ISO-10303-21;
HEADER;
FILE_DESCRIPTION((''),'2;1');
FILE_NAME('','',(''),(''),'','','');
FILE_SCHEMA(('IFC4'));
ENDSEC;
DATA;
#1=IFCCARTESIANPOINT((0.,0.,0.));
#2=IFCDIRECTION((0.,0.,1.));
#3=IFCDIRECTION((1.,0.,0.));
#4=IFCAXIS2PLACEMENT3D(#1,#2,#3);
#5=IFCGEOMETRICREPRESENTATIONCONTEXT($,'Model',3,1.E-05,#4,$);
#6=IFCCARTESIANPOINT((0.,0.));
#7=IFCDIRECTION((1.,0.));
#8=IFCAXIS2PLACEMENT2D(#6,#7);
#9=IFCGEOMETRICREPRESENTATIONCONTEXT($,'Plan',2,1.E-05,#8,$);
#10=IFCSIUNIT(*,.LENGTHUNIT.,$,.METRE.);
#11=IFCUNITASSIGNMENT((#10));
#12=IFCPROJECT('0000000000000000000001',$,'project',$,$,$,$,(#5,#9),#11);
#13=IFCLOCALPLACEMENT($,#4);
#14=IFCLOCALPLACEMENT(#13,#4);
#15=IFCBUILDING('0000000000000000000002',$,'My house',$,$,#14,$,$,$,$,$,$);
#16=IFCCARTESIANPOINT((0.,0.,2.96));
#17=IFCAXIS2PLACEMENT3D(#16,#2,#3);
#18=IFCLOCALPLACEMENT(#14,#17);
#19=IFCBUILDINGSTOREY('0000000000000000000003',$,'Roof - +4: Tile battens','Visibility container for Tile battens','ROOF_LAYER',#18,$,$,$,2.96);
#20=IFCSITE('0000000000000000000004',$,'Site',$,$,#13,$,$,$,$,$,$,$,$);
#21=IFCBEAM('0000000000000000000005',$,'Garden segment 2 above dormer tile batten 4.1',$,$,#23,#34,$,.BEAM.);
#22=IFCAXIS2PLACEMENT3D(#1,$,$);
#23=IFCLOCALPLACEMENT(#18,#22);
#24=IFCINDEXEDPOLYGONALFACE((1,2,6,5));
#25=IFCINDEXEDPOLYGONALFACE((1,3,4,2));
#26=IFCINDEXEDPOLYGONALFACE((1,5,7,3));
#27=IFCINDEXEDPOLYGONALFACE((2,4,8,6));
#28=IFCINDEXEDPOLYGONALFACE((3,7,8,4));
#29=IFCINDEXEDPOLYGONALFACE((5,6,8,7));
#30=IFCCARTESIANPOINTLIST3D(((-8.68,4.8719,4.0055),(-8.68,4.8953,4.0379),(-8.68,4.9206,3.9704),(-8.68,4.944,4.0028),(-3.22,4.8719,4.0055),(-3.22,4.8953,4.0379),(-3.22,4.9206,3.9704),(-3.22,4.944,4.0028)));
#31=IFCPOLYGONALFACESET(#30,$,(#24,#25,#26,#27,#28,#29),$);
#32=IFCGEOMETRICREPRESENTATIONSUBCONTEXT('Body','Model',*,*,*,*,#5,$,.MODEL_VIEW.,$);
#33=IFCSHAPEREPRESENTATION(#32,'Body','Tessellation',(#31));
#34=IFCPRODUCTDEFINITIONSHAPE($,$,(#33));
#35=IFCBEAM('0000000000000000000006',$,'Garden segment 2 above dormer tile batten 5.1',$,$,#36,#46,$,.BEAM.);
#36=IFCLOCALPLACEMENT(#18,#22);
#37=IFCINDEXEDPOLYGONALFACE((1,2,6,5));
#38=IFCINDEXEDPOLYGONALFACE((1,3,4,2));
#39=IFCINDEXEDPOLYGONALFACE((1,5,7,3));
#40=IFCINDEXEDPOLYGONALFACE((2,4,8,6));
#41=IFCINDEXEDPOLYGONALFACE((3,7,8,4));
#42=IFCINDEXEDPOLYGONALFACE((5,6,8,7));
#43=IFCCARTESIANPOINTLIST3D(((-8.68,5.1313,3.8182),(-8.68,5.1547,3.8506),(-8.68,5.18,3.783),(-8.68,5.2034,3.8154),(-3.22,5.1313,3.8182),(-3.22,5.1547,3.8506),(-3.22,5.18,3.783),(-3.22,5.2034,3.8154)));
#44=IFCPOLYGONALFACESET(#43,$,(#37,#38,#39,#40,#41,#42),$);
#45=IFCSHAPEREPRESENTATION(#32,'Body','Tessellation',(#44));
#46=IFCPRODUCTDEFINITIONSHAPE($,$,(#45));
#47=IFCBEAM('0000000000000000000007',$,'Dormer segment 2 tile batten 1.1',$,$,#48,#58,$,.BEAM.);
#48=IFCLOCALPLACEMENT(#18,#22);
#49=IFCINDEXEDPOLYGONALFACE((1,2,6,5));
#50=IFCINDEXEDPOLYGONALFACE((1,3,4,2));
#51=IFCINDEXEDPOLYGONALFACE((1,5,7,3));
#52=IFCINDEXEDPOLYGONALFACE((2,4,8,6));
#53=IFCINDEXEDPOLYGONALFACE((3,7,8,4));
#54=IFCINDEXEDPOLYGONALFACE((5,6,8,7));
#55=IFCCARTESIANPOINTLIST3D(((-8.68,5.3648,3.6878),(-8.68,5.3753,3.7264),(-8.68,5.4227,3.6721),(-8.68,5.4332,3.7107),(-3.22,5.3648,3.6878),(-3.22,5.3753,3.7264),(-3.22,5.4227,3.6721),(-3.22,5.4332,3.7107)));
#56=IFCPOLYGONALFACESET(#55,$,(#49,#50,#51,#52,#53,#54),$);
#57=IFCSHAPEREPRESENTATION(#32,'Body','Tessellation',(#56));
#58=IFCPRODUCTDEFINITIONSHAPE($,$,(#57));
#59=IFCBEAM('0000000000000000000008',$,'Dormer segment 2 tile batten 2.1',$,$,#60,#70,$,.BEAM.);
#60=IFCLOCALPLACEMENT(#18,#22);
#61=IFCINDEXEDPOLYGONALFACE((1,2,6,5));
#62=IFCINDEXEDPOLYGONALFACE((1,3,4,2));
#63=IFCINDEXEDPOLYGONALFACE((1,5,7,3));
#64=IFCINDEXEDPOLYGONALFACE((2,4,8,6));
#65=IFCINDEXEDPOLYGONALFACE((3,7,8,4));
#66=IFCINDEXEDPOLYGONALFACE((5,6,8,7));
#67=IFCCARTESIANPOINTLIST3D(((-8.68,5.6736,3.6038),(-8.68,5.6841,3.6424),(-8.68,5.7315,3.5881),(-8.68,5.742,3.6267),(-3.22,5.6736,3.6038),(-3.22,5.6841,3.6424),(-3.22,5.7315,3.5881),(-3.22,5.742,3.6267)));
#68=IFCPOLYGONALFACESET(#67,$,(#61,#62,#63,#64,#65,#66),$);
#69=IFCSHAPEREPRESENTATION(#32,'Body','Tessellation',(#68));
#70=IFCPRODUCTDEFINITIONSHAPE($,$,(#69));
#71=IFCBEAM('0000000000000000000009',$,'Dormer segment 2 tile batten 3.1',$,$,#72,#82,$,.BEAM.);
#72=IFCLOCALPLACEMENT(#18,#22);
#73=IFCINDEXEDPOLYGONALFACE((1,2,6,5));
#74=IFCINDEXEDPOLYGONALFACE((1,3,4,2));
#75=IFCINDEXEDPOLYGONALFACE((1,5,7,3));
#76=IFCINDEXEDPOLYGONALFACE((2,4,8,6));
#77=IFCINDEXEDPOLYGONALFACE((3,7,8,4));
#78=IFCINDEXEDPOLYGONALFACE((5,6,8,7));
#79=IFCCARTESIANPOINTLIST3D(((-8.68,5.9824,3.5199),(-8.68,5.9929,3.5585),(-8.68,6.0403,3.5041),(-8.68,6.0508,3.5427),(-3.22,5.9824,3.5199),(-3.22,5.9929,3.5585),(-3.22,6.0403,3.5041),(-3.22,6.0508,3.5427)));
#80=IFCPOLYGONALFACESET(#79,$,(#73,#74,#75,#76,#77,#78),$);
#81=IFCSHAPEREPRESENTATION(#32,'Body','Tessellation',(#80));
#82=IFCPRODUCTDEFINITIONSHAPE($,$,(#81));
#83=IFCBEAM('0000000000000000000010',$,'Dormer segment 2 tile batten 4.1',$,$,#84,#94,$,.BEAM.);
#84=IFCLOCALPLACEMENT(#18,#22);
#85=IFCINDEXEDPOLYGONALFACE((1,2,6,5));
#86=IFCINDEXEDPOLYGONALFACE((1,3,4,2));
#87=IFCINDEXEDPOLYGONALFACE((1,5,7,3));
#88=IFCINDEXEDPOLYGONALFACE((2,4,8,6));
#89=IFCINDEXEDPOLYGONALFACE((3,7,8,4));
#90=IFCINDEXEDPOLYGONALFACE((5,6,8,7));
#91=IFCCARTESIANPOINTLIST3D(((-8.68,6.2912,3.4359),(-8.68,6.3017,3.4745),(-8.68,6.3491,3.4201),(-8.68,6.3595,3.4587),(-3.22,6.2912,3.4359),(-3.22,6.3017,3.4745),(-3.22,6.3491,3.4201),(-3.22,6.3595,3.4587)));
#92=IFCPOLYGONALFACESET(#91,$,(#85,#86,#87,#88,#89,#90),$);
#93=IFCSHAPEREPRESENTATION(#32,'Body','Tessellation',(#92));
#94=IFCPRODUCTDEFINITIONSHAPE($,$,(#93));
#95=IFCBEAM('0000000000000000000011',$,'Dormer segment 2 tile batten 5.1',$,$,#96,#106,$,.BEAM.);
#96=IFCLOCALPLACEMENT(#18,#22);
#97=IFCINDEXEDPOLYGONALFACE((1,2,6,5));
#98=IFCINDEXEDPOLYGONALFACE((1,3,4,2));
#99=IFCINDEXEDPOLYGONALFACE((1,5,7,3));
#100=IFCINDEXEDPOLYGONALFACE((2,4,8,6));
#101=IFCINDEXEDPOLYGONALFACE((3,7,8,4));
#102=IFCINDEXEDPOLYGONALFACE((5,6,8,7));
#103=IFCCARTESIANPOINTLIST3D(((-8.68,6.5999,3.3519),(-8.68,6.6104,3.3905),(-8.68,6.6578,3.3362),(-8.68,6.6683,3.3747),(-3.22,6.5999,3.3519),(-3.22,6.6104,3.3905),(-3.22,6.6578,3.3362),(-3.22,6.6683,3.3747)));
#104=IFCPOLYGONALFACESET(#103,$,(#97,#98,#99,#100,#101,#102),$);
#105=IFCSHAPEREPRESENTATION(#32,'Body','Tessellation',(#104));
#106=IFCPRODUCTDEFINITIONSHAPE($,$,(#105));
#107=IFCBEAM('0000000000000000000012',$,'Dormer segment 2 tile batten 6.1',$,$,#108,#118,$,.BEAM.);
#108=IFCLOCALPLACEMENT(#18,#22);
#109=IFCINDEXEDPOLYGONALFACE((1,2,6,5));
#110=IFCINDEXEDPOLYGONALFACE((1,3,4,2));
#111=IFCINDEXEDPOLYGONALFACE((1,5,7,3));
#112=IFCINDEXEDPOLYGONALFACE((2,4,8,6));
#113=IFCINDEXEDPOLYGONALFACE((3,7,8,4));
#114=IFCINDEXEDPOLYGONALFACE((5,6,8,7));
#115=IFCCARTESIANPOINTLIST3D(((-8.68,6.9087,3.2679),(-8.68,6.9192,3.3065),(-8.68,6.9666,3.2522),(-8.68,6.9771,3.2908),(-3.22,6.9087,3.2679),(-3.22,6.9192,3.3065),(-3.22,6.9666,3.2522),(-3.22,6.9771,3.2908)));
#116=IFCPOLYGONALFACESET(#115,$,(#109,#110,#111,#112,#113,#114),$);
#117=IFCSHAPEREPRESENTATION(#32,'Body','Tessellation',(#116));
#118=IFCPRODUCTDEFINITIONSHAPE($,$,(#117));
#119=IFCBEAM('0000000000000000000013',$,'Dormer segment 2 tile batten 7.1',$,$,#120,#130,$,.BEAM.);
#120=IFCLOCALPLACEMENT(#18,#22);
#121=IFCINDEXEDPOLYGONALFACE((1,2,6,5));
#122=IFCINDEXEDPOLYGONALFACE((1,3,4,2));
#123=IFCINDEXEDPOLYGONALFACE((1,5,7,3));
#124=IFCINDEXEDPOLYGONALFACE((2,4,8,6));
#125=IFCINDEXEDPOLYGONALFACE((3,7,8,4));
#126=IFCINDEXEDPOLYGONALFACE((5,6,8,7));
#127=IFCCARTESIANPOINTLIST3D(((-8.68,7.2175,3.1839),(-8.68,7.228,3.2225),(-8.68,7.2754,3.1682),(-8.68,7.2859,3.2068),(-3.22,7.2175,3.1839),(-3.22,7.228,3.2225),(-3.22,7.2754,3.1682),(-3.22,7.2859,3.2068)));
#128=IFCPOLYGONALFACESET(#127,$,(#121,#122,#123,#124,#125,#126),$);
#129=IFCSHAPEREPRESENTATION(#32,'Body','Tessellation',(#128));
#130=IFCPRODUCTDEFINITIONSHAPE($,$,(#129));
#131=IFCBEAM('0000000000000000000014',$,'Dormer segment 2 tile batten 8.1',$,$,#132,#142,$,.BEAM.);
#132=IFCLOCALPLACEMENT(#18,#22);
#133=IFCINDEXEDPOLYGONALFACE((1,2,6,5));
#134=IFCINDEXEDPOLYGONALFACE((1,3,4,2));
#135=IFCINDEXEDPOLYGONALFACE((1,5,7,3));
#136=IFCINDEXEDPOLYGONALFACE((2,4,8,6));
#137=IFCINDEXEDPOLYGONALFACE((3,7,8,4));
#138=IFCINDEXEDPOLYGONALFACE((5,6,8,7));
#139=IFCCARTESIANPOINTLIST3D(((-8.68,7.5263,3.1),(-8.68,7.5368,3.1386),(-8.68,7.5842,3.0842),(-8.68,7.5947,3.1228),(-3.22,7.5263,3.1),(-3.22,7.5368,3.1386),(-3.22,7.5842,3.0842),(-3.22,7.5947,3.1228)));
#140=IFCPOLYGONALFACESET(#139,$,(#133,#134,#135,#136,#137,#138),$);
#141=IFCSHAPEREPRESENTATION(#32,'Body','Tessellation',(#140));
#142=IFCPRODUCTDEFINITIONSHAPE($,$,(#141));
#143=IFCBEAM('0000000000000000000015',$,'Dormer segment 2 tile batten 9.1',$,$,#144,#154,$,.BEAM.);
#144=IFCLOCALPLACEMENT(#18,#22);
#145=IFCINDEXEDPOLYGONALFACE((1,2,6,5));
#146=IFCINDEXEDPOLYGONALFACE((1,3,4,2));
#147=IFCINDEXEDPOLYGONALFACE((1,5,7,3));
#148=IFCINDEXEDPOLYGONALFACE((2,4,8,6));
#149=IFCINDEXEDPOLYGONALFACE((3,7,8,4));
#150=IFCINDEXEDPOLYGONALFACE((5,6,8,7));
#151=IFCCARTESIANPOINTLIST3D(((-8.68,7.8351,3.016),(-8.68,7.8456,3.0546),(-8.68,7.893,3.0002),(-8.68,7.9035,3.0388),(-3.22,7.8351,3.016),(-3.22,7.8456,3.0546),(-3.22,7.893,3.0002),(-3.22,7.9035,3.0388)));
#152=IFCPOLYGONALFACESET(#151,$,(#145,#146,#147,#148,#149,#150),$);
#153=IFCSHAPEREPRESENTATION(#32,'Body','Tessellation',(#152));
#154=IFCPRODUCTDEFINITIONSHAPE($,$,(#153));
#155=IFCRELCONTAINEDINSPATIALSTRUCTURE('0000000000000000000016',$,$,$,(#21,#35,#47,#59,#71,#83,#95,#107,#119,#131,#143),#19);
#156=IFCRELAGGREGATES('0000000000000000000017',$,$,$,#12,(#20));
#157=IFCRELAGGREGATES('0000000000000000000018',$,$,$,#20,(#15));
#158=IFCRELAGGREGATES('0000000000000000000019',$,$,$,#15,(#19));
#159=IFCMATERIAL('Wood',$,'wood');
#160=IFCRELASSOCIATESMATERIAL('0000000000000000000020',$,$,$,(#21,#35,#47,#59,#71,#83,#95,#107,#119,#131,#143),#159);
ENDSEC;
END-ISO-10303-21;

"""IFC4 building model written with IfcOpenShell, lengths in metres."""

from ifc_helpers import new_model, si_unit, frame, origin_with_axes, origin_2d_with_axis, place, context, subcontext, project, spatial, rectangle, extrude, clip, halfspace, source, transform, mapped, material, element, save


model = new_model("IFC4")

# Units and contexts
model_context = context("Model", 3, precision=1e-05, world=origin_with_axes())
plan_context = context("Plan", 2, precision=1e-05, world=origin_2d_with_axis())
body_context = subcontext(model_context, "Body", "Model", "MODEL_VIEW")
ifc_project = project(units=[si_unit("LENGTHUNIT", "METRE")], contexts=[model_context, plan_context])

# Site, building, storey
site_placement = place(None, origin_with_axes())
site = spatial("IfcSite", under=ifc_project, at=site_placement, Name="Site")
building_placement = place(site_placement, origin_with_axes())
building = spatial("IfcBuilding", under=site, at=building_placement, Name="My house")
storey_placement = place(building_placement, frame((0.0, 0.0, 2.96), z_axis=(0.0, 0.0, 1.0), x_axis=(1.0, 0.0, 0.0)))
storey = spatial("IfcBuildingStorey", under=building, at=storey_placement, Name="Roof - +4: Tile battens", Description="Visibility container for Tile battens", ObjectType="ROOF_LAYER", Elevation=2.96)

# Beams
ifc_material = material(Name="Wood", Category="wood")
shared_shape_1 = source(origin_with_axes(), body_context, "Body", "Clipping", [
    clip(clip(extrude(rectangle(XDim=0.06, YDim=0.04), frame((0.0, 0.0, 0.0), z_axis=(1.0, 0.0, 0.0), x_axis=(0.0, 1.0, 0.0)), (0.0, 0.0, 1.0), 5.46), halfspace(frame((-3.22, 3.3416, -6.1772), z_axis=(0.0, -0.810664, -0.585512), x_axis=(-1.0, 0.0, 0.0)), False)), halfspace(frame((-3.22, 7.1922, -3.396), z_axis=(0.0, 0.810664, 0.585512), x_axis=(1.0, 0.0, 0.0)), False)),
])
beam_1_placement = place(storey_placement, frame((-3.22, 4.9079, 4.0042), z_axis=(0.0, 0.585512, 0.810664), x_axis=(1.0, 0.0, 0.0)))
element("IfcBeam", 1, at=beam_1_placement, inside=storey, material=ifc_material, Name="Garden segment 2 above dormer tile batten 4.1", PredefinedType="BEAM", context=body_context, shape_type="MappedRepresentation", body=[
    mapped(shared_shape_1, transform((0.0, 0.0, 0.0), x_axis=(-1.0, 0.0, 0.0), y_axis=(0.0, 1.0, 0.0), z_axis=(0.0, 0.0, 1.0), scale=1.0)),
])
shared_shape_2 = source(origin_with_axes(), body_context, "Body", "Clipping", [
    clip(clip(extrude(rectangle(XDim=0.06, YDim=0.04), frame((0.0, 0.0, 0.0), z_axis=(1.0, 0.0, 0.0), x_axis=(0.0, 1.0, 0.0)), (0.0, 0.0, 1.0), 5.46), halfspace(frame((-3.22, 3.0216, -6.1772), z_axis=(0.0, -0.810664, -0.585512), x_axis=(-1.0, 0.0, 0.0)), False)), halfspace(frame((-3.22, 6.8722, -3.396), z_axis=(0.0, 0.810664, 0.585512), x_axis=(1.0, 0.0, 0.0)), False)),
])
beam_2_placement = place(storey_placement, frame((-3.22, 5.1674, 3.8168), z_axis=(0.0, 0.585512, 0.810664), x_axis=(1.0, 0.0, 0.0)))
element("IfcBeam", 2, at=beam_2_placement, inside=storey, material=ifc_material, Name="Garden segment 2 above dormer tile batten 5.1", PredefinedType="BEAM", context=body_context, shape_type="MappedRepresentation", body=[
    mapped(shared_shape_2, transform((0.0, 0.0, 0.0), x_axis=(-1.0, 0.0, 0.0), y_axis=(0.0, 1.0, 0.0), z_axis=(0.0, 0.0, 1.0), scale=1.0)),
])
shared_shape_3 = source(origin_with_axes(), body_context, "Body", "Clipping", [
    clip(clip(extrude(rectangle(XDim=0.06, YDim=0.04), frame((0.0, 0.0, 0.0), z_axis=(1.0, 0.0, 0.0), x_axis=(0.0, 1.0, 0.0)), (0.0, 0.0, 1.0), 5.46), halfspace(frame((-3.22, 0.3977, -6.793), z_axis=(0.0, -0.964948, -0.262441), x_axis=(-1.0, 0.0, 0.0)), False)), halfspace(frame((-3.22, 4.9812, -5.5464), z_axis=(0.0, 0.964948, 0.262441), x_axis=(1.0, 0.0, 0.0)), False)),
])
beam_3_placement = place(storey_placement, frame((-3.22, 5.399, 3.6992), z_axis=(0.0, 0.262441, 0.964948), x_axis=(1.0, 0.0, 0.0)))
element("IfcBeam", 3, at=beam_3_placement, inside=storey, material=ifc_material, Name="Dormer segment 2 tile batten 1.1", PredefinedType="BEAM", context=body_context, shape_type="MappedRepresentation", body=[
    mapped(shared_shape_3, transform((0.0, 0.0, 0.0), x_axis=(-1.0, 0.0, 0.0), y_axis=(0.0, 1.0, 0.0), z_axis=(0.0, 0.0, 1.0), scale=1.0)),
])
shared_shape_4 = source(origin_with_axes(), body_context, "Body", "Clipping", [
    clip(clip(extrude(rectangle(XDim=0.06, YDim=0.04), frame((0.0, 0.0, 0.0), z_axis=(1.0, 0.0, 0.0), x_axis=(0.0, 1.0, 0.0)), (0.0, 0.0, 1.0), 5.46), halfspace(frame((-3.22, 0.0777, -6.793), z_axis=(0.0, -0.964948, -0.262441), x_axis=(-1.0, 0.0, 0.0)), False)), halfspace(frame((-3.22, 4.6612, -5.5464), z_axis=(0.0, 0.964948, 0.262441), x_axis=(1.0, 0.0, 0.0)), False)),
])
beam_4_placement = place(storey_placement, frame((-3.22, 5.7078, 3.6153), z_axis=(0.0, 0.262441, 0.964948), x_axis=(1.0, 0.0, 0.0)))
element("IfcBeam", 4, at=beam_4_placement, inside=storey, material=ifc_material, Name="Dormer segment 2 tile batten 2.1", PredefinedType="BEAM", context=body_context, shape_type="MappedRepresentation", body=[
    mapped(shared_shape_4, transform((0.0, 0.0, 0.0), x_axis=(-1.0, 0.0, 0.0), y_axis=(0.0, 1.0, 0.0), z_axis=(0.0, 0.0, 1.0), scale=1.0)),
])
shared_shape_5 = source(origin_with_axes(), body_context, "Body", "Clipping", [
    clip(clip(extrude(rectangle(XDim=0.06, YDim=0.04), frame((0.0, 0.0, 0.0), z_axis=(1.0, 0.0, 0.0), x_axis=(0.0, 1.0, 0.0)), (0.0, 0.0, 1.0), 5.46), halfspace(frame((-3.22, -0.2423, -6.793), z_axis=(0.0, -0.964948, -0.262441), x_axis=(-1.0, 0.0, 0.0)), False)), halfspace(frame((-3.22, 4.3412, -5.5464), z_axis=(0.0, 0.964948, 0.262441), x_axis=(1.0, 0.0, 0.0)), False)),
])
beam_5_placement = place(storey_placement, frame((-3.22, 6.0166, 3.5313), z_axis=(0.0, 0.262441, 0.964948), x_axis=(1.0, 0.0, 0.0)))
element("IfcBeam", 5, at=beam_5_placement, inside=storey, material=ifc_material, Name="Dormer segment 2 tile batten 3.1", PredefinedType="BEAM", context=body_context, shape_type="MappedRepresentation", body=[
    mapped(shared_shape_5, transform((0.0, 0.0, 0.0), x_axis=(-1.0, 0.0, 0.0), y_axis=(0.0, 1.0, 0.0), z_axis=(0.0, 0.0, 1.0), scale=1.0)),
])
shared_shape_6 = source(origin_with_axes(), body_context, "Body", "Clipping", [
    clip(clip(extrude(rectangle(XDim=0.06, YDim=0.04), frame((0.0, 0.0, 0.0), z_axis=(1.0, 0.0, 0.0), x_axis=(0.0, 1.0, 0.0)), (0.0, 0.0, 1.0), 5.46), halfspace(frame((-3.22, -0.5623, -6.793), z_axis=(0.0, -0.964948, -0.262441), x_axis=(-1.0, 0.0, 0.0)), False)), halfspace(frame((-3.22, 4.0212, -5.5464), z_axis=(0.0, 0.964948, 0.262441), x_axis=(1.0, 0.0, 0.0)), False)),
])
beam_6_placement = place(storey_placement, frame((-3.22, 6.3254, 3.4473), z_axis=(0.0, 0.262441, 0.964948), x_axis=(1.0, 0.0, 0.0)))
element("IfcBeam", 6, at=beam_6_placement, inside=storey, material=ifc_material, Name="Dormer segment 2 tile batten 4.1", PredefinedType="BEAM", context=body_context, shape_type="MappedRepresentation", body=[
    mapped(shared_shape_6, transform((0.0, 0.0, 0.0), x_axis=(-1.0, 0.0, 0.0), y_axis=(0.0, 1.0, 0.0), z_axis=(0.0, 0.0, 1.0), scale=1.0)),
])
shared_shape_7 = source(origin_with_axes(), body_context, "Body", "Clipping", [
    clip(clip(extrude(rectangle(XDim=0.06, YDim=0.04), frame((0.0, 0.0, 0.0), z_axis=(1.0, 0.0, 0.0), x_axis=(0.0, 1.0, 0.0)), (0.0, 0.0, 1.0), 5.46), halfspace(frame((-3.22, -0.8823, -6.793), z_axis=(0.0, -0.964948, -0.262441), x_axis=(-1.0, 0.0, 0.0)), False)), halfspace(frame((-3.22, 3.7012, -5.5464), z_axis=(0.0, 0.964948, 0.262441), x_axis=(1.0, 0.0, 0.0)), False)),
])
beam_7_placement = place(storey_placement, frame((-3.22, 6.6341, 3.3633), z_axis=(0.0, 0.262441, 0.964948), x_axis=(1.0, 0.0, 0.0)))
element("IfcBeam", 7, at=beam_7_placement, inside=storey, material=ifc_material, Name="Dormer segment 2 tile batten 5.1", PredefinedType="BEAM", context=body_context, shape_type="MappedRepresentation", body=[
    mapped(shared_shape_7, transform((0.0, 0.0, 0.0), x_axis=(-1.0, 0.0, 0.0), y_axis=(0.0, 1.0, 0.0), z_axis=(0.0, 0.0, 1.0), scale=1.0)),
])
shared_shape_8 = source(origin_with_axes(), body_context, "Body", "Clipping", [
    clip(clip(extrude(rectangle(XDim=0.06, YDim=0.04), frame((0.0, 0.0, 0.0), z_axis=(1.0, 0.0, 0.0), x_axis=(0.0, 1.0, 0.0)), (0.0, 0.0, 1.0), 5.46), halfspace(frame((-3.22, -1.2023, -6.793), z_axis=(0.0, -0.964948, -0.262441), x_axis=(-1.0, 0.0, 0.0)), False)), halfspace(frame((-3.22, 3.3812, -5.5464), z_axis=(0.0, 0.964948, 0.262441), x_axis=(1.0, 0.0, 0.0)), False)),
])
beam_8_placement = place(storey_placement, frame((-3.22, 6.9429, 3.2793), z_axis=(0.0, 0.262441, 0.964948), x_axis=(1.0, 0.0, 0.0)))
element("IfcBeam", 8, at=beam_8_placement, inside=storey, material=ifc_material, Name="Dormer segment 2 tile batten 6.1", PredefinedType="BEAM", context=body_context, shape_type="MappedRepresentation", body=[
    mapped(shared_shape_8, transform((0.0, 0.0, 0.0), x_axis=(-1.0, 0.0, 0.0), y_axis=(0.0, 1.0, 0.0), z_axis=(0.0, 0.0, 1.0), scale=1.0)),
])
shared_shape_9 = source(origin_with_axes(), body_context, "Body", "Clipping", [
    clip(clip(extrude(rectangle(XDim=0.06, YDim=0.04), frame((0.0, 0.0, 0.0), z_axis=(1.0, 0.0, 0.0), x_axis=(0.0, 1.0, 0.0)), (0.0, 0.0, 1.0), 5.46), halfspace(frame((-3.22, -1.5223, -6.793), z_axis=(0.0, -0.964948, -0.262441), x_axis=(-1.0, 0.0, 0.0)), False)), halfspace(frame((-3.22, 3.0612, -5.5464), z_axis=(0.0, 0.964948, 0.262441), x_axis=(1.0, 0.0, 0.0)), False)),
])
beam_9_placement = place(storey_placement, frame((-3.22, 7.2517, 3.1954), z_axis=(0.0, 0.262441, 0.964948), x_axis=(1.0, 0.0, 0.0)))
element("IfcBeam", 9, at=beam_9_placement, inside=storey, material=ifc_material, Name="Dormer segment 2 tile batten 7.1", PredefinedType="BEAM", context=body_context, shape_type="MappedRepresentation", body=[
    mapped(shared_shape_9, transform((0.0, 0.0, 0.0), x_axis=(-1.0, 0.0, 0.0), y_axis=(0.0, 1.0, 0.0), z_axis=(0.0, 0.0, 1.0), scale=1.0)),
])
shared_shape_10 = source(origin_with_axes(), body_context, "Body", "Clipping", [
    clip(clip(extrude(rectangle(XDim=0.06, YDim=0.04), frame((0.0, 0.0, 0.0), z_axis=(1.0, 0.0, 0.0), x_axis=(0.0, 1.0, 0.0)), (0.0, 0.0, 1.0), 5.46), halfspace(frame((-3.22, -1.8423, -6.793), z_axis=(0.0, -0.964948, -0.262441), x_axis=(-1.0, 0.0, 0.0)), False)), halfspace(frame((-3.22, 2.7412, -5.5464), z_axis=(0.0, 0.964948, 0.262441), x_axis=(1.0, 0.0, 0.0)), False)),
])
beam_10_placement = place(storey_placement, frame((-3.22, 7.5605, 3.1114), z_axis=(0.0, 0.262441, 0.964948), x_axis=(1.0, 0.0, 0.0)))
element("IfcBeam", 10, at=beam_10_placement, inside=storey, material=ifc_material, Name="Dormer segment 2 tile batten 8.1", PredefinedType="BEAM", context=body_context, shape_type="MappedRepresentation", body=[
    mapped(shared_shape_10, transform((0.0, 0.0, 0.0), x_axis=(-1.0, 0.0, 0.0), y_axis=(0.0, 1.0, 0.0), z_axis=(0.0, 0.0, 1.0), scale=1.0)),
])
shared_shape_11 = source(origin_with_axes(), body_context, "Body", "Clipping", [
    clip(clip(extrude(rectangle(XDim=0.06, YDim=0.04), frame((0.0, 0.0, 0.0), z_axis=(1.0, 0.0, 0.0), x_axis=(0.0, 1.0, 0.0)), (0.0, 0.0, 1.0), 5.46), halfspace(frame((-3.22, -2.1623, -6.793), z_axis=(0.0, -0.964948, -0.262441), x_axis=(-1.0, 0.0, 0.0)), False)), halfspace(frame((-3.22, 2.4212, -5.5464), z_axis=(0.0, 0.964948, 0.262441), x_axis=(1.0, 0.0, 0.0)), False)),
])
beam_11_placement = place(storey_placement, frame((-3.22, 7.8693, 3.0274), z_axis=(0.0, 0.262441, 0.964948), x_axis=(1.0, 0.0, 0.0)))
element("IfcBeam", 11, at=beam_11_placement, inside=storey, material=ifc_material, Name="Dormer segment 2 tile batten 9.1", PredefinedType="BEAM", context=body_context, shape_type="MappedRepresentation", body=[
    mapped(shared_shape_11, transform((0.0, 0.0, 0.0), x_axis=(-1.0, 0.0, 0.0), y_axis=(0.0, 1.0, 0.0), z_axis=(0.0, 0.0, 1.0), scale=1.0)),
])

save(model, "model.ifc")
